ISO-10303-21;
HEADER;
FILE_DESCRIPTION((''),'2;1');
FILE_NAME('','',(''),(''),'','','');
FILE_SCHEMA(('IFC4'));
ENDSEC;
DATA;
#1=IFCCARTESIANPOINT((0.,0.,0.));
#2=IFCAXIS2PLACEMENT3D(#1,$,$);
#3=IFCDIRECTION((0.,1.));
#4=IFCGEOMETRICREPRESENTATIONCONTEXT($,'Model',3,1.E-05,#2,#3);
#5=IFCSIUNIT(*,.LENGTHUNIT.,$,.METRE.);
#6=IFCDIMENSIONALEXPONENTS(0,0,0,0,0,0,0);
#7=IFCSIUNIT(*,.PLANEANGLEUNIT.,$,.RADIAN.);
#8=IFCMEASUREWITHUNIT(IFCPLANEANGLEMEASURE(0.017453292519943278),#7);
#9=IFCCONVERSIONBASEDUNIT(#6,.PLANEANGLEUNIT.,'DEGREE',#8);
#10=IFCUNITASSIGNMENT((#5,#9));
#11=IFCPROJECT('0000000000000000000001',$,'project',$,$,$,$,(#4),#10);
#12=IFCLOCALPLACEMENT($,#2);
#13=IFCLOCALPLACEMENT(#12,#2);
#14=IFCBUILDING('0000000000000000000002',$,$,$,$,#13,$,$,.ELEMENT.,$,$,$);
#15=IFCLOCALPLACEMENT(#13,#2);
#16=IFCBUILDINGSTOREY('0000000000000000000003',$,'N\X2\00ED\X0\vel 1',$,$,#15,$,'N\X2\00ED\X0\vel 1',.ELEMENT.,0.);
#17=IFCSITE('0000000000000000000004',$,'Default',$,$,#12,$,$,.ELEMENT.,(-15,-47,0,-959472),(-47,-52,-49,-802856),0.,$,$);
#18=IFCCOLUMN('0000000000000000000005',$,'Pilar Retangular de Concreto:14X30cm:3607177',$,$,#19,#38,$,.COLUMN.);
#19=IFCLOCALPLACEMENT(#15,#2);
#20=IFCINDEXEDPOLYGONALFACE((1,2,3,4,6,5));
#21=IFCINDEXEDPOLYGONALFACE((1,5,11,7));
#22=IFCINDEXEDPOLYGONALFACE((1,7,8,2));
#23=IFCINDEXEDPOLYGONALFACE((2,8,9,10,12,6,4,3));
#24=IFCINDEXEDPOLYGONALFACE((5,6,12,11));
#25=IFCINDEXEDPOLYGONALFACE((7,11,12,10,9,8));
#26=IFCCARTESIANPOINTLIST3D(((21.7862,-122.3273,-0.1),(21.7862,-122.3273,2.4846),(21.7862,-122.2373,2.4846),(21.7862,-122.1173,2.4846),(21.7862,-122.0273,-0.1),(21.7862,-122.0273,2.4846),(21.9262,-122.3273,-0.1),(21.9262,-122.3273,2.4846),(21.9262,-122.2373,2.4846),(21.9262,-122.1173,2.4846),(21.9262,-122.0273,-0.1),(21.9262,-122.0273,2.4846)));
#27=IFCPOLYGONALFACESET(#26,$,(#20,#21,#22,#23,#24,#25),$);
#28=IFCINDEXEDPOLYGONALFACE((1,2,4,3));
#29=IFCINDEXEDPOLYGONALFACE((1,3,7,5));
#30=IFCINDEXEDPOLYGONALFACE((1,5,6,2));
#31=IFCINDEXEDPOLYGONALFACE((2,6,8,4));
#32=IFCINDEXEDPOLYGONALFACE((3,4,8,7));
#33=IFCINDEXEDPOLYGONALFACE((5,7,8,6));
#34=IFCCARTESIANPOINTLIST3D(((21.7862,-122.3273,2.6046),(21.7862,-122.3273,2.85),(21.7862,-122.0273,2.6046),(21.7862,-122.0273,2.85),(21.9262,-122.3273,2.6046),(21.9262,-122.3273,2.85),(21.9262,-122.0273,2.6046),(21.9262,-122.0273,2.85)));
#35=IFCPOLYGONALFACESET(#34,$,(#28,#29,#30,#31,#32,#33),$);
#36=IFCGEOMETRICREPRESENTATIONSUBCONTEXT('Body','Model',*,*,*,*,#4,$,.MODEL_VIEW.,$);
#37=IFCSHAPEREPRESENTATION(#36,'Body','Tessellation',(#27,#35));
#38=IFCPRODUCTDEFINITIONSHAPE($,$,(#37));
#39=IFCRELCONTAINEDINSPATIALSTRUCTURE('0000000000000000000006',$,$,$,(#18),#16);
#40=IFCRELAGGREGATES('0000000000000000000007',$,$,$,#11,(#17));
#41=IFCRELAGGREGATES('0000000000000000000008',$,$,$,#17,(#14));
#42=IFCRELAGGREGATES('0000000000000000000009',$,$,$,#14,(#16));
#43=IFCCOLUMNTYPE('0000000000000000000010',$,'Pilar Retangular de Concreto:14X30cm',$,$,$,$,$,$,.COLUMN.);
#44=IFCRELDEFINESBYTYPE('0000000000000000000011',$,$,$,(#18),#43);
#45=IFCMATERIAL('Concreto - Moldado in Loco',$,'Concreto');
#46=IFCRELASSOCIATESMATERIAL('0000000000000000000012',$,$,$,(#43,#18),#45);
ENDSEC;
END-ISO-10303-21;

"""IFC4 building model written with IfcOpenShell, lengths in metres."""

from ifc_helpers import new_model, entity, si_unit, converted_unit, direction, frame, origin, place, context, subcontext, project, spatial, indexed_curve, outline, extrude, source, transform, mapped, material, type_object, type_shapes, element, save


model = new_model("IFC4")

# Units and contexts
model_context = context("Model", 3, precision=1e-05, world=origin(), true_north=direction((0.0, 1.0)))
body_context = subcontext(model_context, "Body", "Model", "MODEL_VIEW")
ifc_project = project(units=[si_unit("LENGTHUNIT", "METRE"), converted_unit("PLANEANGLEUNIT", "DEGREE", entity("IfcPlaneAngleMeasure", 0.017453292519943278), si_unit("PLANEANGLEUNIT", "RADIAN"), dimensions=[0, 0, 0, 0, 0, 0, 0])], contexts=[model_context])

# Site, building, storey
site_placement = place(None, origin())
site = spatial("IfcSite", under=ifc_project, at=site_placement, Name="Default", CompositionType="ELEMENT", RefLatitude=(-15, -47, 0, -959472), RefLongitude=(-47, -52, -49, -802856), RefElevation=0.0)
building_placement = place(site_placement, origin())
building = spatial("IfcBuilding", under=site, at=building_placement, CompositionType="ELEMENT")
storey_placement = place(building_placement, origin())
storey = spatial("IfcBuildingStorey", under=building, at=storey_placement, Name="Nível 1", LongName="Nível 1", CompositionType="ELEMENT", Elevation=0.0)

# Column
ifc_material_1 = material(Name="Concreto - Moldado in Loco", Category="Concreto")
column_type_1 = type_object("IfcColumnType", Name="Pilar Retangular de Concreto:14X30cm", PredefinedType="COLUMN", material=ifc_material_1)
shared_shape_1 = source(origin(), body_context, "Body", "SweptSolid", [
    extrude(outline(indexed_curve([(-1.723, -0.15), (0.8615, -0.15), (0.8615, -0.06), (0.8615, 0.06), (0.8615, 0.15), (-1.723, 0.15), (-1.723, -0.15)], self_intersect=False)), frame((21.7862, -122.1773, 1.623), z_axis=(1.0, 0.0, 0.0), x_axis=(0.0, 0.0, 1.0)), (0.0, 0.0, 1.0), 0.14),
    extrude(outline(indexed_curve([(-0.1227, -0.15), (0.1227, -0.15), (0.1227, 0.15), (-0.1227, 0.15), (-0.1227, -0.15)], self_intersect=False)), frame((21.7862, -122.1773, 2.7273), z_axis=(1.0, 0.0, 0.0), x_axis=(0.0, 0.0, -1.0)), (0.0, 0.0, 1.0), 0.14),
])
type_shapes(column_type_1, [shared_shape_1])
column_1_placement = place(storey_placement, origin())
element("IfcColumn", 1, at=column_1_placement, inside=storey, type_object=column_type_1, material=ifc_material_1, Name="Pilar Retangular de Concreto:14X30cm:3607177", PredefinedType="COLUMN", context=body_context, shape_type="MappedRepresentation", body=[
    mapped(shared_shape_1, transform((0.0, 0.0, 0.0), scale=1.0)),
])

save(model, "model.ifc")
